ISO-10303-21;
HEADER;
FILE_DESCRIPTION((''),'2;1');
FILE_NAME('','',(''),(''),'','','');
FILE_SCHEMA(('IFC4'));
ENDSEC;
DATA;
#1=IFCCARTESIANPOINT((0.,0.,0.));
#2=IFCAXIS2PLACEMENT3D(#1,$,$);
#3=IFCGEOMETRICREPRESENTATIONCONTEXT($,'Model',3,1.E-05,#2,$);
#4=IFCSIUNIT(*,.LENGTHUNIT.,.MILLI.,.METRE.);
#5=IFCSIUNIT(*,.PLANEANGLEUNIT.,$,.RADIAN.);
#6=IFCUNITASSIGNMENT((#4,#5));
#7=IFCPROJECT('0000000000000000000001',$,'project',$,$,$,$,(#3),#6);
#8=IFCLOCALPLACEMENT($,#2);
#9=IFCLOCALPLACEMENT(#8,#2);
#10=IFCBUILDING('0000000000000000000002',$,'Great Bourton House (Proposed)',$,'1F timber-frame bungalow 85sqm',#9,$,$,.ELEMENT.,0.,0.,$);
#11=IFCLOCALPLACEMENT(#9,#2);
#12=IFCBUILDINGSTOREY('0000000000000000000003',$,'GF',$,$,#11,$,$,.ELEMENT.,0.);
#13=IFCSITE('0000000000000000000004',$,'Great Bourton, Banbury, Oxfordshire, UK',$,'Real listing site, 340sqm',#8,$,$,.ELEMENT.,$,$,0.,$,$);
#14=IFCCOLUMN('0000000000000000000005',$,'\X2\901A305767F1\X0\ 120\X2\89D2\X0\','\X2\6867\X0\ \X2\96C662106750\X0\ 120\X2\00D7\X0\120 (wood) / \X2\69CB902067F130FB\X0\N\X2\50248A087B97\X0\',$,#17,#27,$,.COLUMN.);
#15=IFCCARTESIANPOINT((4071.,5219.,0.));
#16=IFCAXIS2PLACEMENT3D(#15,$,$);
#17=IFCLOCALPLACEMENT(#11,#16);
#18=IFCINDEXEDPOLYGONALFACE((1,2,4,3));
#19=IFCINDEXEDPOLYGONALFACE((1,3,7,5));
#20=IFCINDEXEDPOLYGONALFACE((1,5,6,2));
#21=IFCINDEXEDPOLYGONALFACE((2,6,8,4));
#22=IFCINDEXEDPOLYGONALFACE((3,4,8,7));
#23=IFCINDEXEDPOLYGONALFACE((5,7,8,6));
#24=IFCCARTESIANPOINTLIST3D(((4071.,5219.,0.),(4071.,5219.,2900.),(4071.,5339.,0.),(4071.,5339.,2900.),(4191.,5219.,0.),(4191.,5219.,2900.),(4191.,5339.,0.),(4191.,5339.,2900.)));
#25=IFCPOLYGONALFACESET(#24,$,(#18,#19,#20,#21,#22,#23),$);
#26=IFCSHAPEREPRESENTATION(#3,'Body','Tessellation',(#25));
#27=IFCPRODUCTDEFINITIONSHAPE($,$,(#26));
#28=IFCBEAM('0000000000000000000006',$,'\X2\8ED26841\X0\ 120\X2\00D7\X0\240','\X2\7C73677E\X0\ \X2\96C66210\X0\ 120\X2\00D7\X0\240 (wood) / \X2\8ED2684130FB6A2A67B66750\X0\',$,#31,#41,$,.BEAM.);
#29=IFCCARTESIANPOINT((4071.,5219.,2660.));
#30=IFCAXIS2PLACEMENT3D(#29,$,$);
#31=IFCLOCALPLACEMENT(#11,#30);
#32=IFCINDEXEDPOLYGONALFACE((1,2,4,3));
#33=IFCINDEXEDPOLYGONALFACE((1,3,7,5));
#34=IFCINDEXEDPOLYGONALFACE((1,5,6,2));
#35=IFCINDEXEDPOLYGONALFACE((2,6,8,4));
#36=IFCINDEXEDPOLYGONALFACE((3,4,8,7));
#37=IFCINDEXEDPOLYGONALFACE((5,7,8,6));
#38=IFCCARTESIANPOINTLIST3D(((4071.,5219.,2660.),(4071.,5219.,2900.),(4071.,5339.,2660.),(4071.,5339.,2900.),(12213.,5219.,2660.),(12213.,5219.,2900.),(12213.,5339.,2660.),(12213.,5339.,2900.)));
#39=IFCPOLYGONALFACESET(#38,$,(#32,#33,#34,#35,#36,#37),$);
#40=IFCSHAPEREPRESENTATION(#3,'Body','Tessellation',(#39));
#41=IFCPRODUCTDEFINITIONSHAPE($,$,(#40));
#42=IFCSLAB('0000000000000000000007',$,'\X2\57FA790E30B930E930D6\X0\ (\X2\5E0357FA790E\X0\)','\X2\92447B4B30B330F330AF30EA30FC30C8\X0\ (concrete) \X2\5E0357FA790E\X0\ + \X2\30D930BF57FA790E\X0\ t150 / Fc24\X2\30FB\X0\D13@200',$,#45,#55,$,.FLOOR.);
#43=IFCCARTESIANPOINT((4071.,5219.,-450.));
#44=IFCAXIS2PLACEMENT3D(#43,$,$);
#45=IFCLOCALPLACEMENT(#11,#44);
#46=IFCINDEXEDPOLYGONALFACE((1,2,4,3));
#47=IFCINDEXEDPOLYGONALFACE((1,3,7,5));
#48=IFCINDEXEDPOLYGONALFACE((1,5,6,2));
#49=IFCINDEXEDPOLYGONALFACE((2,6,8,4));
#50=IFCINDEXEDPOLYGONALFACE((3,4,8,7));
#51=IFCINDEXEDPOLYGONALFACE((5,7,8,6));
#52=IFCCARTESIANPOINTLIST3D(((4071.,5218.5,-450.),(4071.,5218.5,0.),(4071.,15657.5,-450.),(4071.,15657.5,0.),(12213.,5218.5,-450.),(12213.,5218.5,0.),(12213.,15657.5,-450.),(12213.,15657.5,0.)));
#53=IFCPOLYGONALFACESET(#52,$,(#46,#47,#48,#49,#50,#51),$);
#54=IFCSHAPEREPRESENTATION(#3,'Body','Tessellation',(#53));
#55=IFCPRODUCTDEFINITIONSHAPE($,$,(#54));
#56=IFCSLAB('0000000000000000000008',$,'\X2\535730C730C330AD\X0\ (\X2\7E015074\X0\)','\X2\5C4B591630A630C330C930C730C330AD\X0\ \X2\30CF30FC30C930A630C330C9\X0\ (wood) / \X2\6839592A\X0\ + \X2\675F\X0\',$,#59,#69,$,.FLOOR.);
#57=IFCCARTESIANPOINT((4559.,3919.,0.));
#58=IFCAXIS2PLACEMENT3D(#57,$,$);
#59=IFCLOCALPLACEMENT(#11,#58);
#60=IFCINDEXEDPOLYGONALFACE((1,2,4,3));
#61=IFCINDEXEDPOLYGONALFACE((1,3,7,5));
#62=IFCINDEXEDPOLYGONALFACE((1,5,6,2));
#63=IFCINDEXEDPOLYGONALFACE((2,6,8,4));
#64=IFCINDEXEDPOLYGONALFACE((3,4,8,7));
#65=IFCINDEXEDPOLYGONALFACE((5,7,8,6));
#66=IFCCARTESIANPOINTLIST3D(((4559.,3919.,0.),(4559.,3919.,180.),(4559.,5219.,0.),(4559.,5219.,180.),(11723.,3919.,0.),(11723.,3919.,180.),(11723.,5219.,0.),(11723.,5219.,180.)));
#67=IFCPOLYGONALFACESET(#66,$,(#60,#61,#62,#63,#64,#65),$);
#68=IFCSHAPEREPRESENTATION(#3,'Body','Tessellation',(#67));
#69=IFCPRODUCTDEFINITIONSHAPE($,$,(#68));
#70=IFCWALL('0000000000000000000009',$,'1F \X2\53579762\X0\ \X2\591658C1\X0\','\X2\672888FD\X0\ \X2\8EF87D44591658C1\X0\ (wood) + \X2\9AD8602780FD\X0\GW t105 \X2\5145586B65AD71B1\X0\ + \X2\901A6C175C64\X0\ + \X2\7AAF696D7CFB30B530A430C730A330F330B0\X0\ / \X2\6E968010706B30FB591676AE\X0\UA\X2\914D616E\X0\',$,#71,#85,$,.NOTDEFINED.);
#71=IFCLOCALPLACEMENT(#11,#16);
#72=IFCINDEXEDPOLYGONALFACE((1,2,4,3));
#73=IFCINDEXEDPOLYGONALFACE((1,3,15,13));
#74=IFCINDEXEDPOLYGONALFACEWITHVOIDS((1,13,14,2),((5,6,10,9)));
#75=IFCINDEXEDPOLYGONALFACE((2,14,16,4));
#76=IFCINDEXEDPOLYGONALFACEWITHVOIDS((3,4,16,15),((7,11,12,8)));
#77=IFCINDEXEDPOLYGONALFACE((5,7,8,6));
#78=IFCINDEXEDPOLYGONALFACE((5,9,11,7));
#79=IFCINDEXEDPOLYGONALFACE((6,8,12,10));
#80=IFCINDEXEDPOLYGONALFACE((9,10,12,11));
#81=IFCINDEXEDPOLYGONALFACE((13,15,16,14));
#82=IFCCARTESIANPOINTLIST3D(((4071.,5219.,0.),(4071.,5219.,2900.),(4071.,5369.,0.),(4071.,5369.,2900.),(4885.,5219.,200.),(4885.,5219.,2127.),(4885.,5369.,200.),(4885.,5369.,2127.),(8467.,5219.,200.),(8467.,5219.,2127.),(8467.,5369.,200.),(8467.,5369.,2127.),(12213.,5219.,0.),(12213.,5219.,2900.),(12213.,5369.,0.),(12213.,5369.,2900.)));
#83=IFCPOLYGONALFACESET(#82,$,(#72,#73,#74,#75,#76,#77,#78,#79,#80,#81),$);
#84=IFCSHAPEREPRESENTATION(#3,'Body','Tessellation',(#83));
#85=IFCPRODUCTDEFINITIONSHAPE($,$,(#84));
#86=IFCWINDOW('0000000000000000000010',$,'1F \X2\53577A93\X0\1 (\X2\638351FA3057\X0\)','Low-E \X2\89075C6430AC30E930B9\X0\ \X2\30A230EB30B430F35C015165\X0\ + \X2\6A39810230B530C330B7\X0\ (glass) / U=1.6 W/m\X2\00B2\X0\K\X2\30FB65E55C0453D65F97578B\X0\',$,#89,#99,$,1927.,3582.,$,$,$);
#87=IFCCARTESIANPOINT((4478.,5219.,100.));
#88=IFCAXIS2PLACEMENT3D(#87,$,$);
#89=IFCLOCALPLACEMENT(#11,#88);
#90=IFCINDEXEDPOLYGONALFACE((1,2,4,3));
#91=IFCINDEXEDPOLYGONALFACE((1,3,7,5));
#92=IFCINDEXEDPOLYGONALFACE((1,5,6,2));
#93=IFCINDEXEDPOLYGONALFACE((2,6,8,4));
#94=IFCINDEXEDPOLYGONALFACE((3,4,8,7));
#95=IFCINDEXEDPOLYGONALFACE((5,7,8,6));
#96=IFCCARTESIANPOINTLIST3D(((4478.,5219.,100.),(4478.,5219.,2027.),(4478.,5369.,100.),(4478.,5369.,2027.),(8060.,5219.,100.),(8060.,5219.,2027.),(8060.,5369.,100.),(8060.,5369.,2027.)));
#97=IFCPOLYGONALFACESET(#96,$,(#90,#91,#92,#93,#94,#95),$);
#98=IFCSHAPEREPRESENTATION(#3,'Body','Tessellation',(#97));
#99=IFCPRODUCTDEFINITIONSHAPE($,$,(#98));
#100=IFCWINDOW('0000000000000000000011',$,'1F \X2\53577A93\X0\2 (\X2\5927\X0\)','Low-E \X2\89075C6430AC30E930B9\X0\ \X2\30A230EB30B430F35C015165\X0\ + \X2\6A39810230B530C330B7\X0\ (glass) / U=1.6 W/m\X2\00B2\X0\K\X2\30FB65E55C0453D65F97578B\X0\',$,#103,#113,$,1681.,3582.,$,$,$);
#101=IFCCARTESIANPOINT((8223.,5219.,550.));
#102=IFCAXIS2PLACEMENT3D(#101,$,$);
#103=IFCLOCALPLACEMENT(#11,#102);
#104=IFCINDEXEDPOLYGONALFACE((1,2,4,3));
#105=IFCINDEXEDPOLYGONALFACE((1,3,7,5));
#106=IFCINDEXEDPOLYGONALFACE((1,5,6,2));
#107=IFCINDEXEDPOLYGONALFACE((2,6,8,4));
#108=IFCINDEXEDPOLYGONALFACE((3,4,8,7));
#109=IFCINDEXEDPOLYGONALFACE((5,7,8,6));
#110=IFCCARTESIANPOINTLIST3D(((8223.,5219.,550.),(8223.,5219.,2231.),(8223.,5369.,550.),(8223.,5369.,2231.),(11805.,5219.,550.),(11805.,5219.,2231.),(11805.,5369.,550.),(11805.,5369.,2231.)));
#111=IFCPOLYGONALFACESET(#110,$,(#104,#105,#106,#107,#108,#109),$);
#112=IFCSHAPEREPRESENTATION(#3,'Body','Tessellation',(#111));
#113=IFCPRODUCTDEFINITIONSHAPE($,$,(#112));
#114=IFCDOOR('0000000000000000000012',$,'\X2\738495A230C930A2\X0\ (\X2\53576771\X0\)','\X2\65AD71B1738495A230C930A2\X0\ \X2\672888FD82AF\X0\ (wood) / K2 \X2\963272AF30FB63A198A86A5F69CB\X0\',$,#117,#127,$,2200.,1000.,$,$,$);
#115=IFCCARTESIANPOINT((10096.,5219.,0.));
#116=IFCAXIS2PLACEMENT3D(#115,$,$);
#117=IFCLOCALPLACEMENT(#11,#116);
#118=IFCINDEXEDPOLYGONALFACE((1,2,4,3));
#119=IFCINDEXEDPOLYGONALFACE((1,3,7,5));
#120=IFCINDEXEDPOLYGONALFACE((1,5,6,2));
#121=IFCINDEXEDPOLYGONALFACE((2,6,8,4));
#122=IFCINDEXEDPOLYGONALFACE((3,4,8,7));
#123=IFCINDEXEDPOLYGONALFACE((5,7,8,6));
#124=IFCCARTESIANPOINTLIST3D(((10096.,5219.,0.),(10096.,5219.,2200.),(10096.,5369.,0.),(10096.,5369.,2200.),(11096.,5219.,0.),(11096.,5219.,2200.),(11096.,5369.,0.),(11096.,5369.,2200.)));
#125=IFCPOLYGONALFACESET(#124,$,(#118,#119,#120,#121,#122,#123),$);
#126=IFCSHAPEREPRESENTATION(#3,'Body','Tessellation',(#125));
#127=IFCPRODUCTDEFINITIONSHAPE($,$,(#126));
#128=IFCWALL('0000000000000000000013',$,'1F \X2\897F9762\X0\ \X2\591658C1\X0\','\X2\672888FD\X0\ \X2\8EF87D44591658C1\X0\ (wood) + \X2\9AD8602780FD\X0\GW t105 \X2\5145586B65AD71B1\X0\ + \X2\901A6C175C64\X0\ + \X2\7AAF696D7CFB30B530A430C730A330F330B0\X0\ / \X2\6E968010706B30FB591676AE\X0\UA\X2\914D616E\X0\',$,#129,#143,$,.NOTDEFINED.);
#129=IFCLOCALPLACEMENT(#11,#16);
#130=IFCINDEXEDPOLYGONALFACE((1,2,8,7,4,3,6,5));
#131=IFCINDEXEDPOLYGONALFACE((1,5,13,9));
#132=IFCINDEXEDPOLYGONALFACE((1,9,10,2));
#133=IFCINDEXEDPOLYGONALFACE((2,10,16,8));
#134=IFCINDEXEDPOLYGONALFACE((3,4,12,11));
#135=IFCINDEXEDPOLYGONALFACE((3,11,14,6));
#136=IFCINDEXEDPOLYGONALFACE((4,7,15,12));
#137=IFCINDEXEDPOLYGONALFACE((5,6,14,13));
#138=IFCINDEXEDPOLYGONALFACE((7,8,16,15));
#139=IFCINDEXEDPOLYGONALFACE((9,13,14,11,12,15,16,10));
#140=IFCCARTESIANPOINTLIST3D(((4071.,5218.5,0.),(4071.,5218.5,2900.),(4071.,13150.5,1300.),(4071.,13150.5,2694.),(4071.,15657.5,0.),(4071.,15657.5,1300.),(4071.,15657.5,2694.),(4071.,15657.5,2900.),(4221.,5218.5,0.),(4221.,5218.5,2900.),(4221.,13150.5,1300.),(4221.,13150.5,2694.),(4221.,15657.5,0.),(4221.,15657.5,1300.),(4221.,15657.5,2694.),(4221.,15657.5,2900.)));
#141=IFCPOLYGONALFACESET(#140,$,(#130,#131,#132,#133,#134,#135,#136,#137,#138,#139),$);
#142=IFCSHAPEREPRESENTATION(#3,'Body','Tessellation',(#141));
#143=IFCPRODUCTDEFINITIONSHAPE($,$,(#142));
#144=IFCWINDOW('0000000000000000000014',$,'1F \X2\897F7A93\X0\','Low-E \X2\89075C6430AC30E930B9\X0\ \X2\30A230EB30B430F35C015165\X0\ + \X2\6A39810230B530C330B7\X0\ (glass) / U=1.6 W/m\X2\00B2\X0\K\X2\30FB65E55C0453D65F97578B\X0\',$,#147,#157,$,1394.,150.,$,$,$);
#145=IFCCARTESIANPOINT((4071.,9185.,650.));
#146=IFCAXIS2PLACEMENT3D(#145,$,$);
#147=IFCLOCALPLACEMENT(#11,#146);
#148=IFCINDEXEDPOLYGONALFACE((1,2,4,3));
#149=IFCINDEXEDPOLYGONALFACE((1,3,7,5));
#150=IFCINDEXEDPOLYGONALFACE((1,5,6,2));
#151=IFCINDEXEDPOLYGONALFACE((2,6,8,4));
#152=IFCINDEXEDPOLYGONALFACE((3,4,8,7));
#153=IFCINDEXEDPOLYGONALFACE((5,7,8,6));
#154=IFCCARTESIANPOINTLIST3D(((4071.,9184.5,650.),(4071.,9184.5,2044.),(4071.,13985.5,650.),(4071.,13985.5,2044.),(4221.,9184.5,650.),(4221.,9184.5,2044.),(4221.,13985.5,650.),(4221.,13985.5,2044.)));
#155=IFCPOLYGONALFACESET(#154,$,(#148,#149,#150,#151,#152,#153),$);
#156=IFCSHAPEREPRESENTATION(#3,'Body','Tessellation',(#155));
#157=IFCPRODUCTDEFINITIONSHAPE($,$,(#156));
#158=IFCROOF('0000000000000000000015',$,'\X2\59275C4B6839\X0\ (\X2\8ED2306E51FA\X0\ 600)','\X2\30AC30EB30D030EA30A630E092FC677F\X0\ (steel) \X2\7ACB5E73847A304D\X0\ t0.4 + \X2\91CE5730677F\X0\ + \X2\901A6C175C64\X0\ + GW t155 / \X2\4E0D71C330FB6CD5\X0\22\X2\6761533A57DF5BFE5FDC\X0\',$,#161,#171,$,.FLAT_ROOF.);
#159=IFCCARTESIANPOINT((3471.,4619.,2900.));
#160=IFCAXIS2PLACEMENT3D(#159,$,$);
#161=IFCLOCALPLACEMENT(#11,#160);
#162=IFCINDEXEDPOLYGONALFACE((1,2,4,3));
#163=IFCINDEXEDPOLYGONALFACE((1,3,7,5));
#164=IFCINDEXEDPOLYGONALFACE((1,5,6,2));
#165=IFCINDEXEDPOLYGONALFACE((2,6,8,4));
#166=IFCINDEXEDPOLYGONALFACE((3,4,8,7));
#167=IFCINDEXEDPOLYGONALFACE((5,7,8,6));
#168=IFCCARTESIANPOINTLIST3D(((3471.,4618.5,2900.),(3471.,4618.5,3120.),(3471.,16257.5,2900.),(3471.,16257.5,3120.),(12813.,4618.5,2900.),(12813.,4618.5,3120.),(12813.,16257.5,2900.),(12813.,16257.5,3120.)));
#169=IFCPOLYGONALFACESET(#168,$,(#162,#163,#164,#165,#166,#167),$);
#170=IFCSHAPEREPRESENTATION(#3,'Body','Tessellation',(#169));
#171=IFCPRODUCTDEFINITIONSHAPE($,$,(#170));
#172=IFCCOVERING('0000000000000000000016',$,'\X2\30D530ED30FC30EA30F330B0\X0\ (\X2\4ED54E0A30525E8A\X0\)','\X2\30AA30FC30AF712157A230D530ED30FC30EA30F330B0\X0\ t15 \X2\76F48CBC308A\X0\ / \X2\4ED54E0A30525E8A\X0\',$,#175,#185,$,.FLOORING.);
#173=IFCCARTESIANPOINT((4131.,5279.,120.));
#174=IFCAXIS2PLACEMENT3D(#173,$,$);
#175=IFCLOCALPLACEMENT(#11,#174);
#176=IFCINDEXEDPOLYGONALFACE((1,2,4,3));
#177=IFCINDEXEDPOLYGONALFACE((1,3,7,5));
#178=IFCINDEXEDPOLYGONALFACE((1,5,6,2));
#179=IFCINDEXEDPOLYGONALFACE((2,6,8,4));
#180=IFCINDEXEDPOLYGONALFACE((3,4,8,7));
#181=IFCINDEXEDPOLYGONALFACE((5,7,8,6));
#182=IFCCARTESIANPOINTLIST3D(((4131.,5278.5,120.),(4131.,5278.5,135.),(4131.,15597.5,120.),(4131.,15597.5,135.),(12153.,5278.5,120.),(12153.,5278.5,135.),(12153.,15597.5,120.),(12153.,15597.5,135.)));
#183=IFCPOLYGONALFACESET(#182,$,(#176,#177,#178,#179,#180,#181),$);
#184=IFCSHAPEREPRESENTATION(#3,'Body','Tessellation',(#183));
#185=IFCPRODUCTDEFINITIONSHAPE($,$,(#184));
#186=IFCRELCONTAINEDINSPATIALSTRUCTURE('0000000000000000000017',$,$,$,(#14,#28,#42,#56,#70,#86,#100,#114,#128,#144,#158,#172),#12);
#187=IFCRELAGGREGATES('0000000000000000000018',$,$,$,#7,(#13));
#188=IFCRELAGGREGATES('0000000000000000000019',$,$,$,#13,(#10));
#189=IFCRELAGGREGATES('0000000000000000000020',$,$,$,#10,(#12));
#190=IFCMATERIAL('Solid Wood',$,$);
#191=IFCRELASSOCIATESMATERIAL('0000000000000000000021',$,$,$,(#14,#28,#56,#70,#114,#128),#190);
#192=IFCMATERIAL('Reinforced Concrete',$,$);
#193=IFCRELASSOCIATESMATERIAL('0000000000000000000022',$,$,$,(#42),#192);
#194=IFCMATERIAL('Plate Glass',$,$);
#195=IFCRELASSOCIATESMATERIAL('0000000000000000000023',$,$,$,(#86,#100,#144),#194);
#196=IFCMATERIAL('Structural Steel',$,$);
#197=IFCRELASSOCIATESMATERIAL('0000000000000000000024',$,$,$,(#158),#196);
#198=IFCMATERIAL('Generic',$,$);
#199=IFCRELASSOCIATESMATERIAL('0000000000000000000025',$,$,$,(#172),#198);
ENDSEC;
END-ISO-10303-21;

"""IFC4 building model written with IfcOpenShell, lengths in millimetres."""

from ifc_helpers import new_model, si_unit, frame, frame_2d, origin, place, context, project, spatial, rectangle, extrude, material, element, fill, save


model = new_model("IFC4")

# Units and contexts
model_context = context("Model", 3, precision=1e-05, world=origin())
ifc_project = project(units=[si_unit("LENGTHUNIT", "METRE", prefix="MILLI"), si_unit("PLANEANGLEUNIT", "RADIAN")], contexts=[model_context])

# Site, building, storey
site_placement = place(None, origin())
site = spatial("IfcSite", under=ifc_project, at=site_placement, Name="Great Bourton, Banbury, Oxfordshire, UK", ObjectType="Real listing site, 340sqm", CompositionType="ELEMENT", RefElevation=0.0)
building_placement = place(site_placement, origin())
building = spatial("IfcBuilding", under=site, at=building_placement, Name="Great Bourton House (Proposed)", ObjectType="1F timber-frame bungalow 85sqm", CompositionType="ELEMENT", ElevationOfRefHeight=0.0, ElevationOfTerrain=0.0)
storey_placement = place(building_placement, origin())
storey = spatial("IfcBuildingStorey", under=building, at=storey_placement, Name="GF", CompositionType="ELEMENT", Elevation=0.0)

# Column
ifc_material_1 = material(Name="Solid Wood")
column_1_placement = place(storey_placement, frame((4071.0, 5219.0, 0.0)))
element("IfcColumn", 1, at=column_1_placement, inside=storey, material=ifc_material_1, Name="通し柱 120角", Description="桧 集成材 120×120 (wood) / 構造柱・N値計算", PredefinedType="COLUMN", context=model_context, shape_type="SweptSolid", body=[
    extrude(rectangle(XDim=120.0, YDim=120.0, at=frame_2d((60.0, 60.0))), frame((4071.0, 5219.0, 0.0)), (0.0, 0.0, 1.0), 2900.0),
])

# Beam
beam_1_placement = place(storey_placement, frame((4071.0, 5219.0, 2660.0)))
element("IfcBeam", 2, at=beam_1_placement, inside=storey, material=ifc_material_1, Name="軒桁 120×240", Description="米松 集成 120×240 (wood) / 軒桁・横架材", PredefinedType="BEAM", context=model_context, shape_type="SweptSolid", body=[
    extrude(rectangle(XDim=8142.0, YDim=120.0, at=frame_2d((4071.0, 60.0))), frame((4071.0, 5219.0, 2660.0)), (0.0, 0.0, 1.0), 240.0),
])

# Slabs
ifc_material_2 = material(Name="Reinforced Concrete")
slab_1_placement = place(storey_placement, frame((4071.0, 5219.0, -450.0)))
element("IfcSlab", 3, at=slab_1_placement, inside=storey, material=ifc_material_2, Name="基礎スラブ (布基礎)", Description="鉄筋コンクリート (concrete) 布基礎 + ベタ基礎 t150 / Fc24・D13@200", PredefinedType="FLOOR", context=model_context, shape_type="SweptSolid", body=[
    extrude(rectangle(XDim=8142.0, YDim=10439.0, at=frame_2d((4071.0, 5219.0))), frame((4071.0, 5219.0, -450.0)), (0.0, 0.0, 1.0), 450.0),
])
slab_2_placement = place(storey_placement, frame((4559.0, 3919.0, 0.0)))
element("IfcSlab", 4, at=slab_2_placement, inside=storey, material=ifc_material_1, Name="南デッキ (縁側)", Description="屋外ウッドデッキ ハードウッド (wood) / 根太 + 束", PredefinedType="FLOOR", context=model_context, shape_type="SweptSolid", body=[
    extrude(rectangle(XDim=7164.0, YDim=1300.0, at=frame_2d((3582.0, 650.0))), frame((4559.0, 3919.0, 0.0)), (0.0, 0.0, 1.0), 180.0),
])

# Wall, openings, windows, door
wall_1_placement = place(storey_placement, frame((4071.0, 5219.0, 0.0)))
wall_1 = element("IfcWall", 5, at=wall_1_placement, inside=storey, material=ifc_material_1, Name="1F 南面 外壁", Description="木製 軸組外壁 (wood) + 高性能GW t105 充填断熱 + 通気層 + 窯業系サイディング / 準耐火・外皮UA配慮", PredefinedType="NOTDEFINED", context=model_context, shape_type="SweptSolid", body=[
    extrude(rectangle(XDim=8142.0, YDim=150.0, at=frame_2d((4071.0, 75.0))), frame((4071.0, 5219.0, 0.0)), (0.0, 0.0, 1.0), 2900.0),
])
opening_1_placement = place(storey_placement, frame((4478.0, 5219.0, 100.0)))
opening_1 = element("IfcOpeningElement", 6, at=opening_1_placement, cuts=wall_1, PredefinedType="NOTDEFINED", context=model_context, shape_type="SweptSolid", body=[
    extrude(rectangle(XDim=3582.0, YDim=150.0, at=frame_2d((1791.0, 75.0))), frame((4478.0, 5219.0, 100.0)), (0.0, 0.0, 1.0), 1927.0),
])
opening_2_placement = place(storey_placement, frame((8223.0, 5219.0, 550.0)))
opening_2 = element("IfcOpeningElement", 7, at=opening_2_placement, cuts=wall_1, PredefinedType="NOTDEFINED", context=model_context, shape_type="SweptSolid", body=[
    extrude(rectangle(XDim=3582.0, YDim=150.0, at=frame_2d((1791.0, 75.0))), frame((8223.0, 5219.0, 550.0)), (0.0, 0.0, 1.0), 1681.0),
])
opening_3_placement = place(storey_placement, frame((10096.0, 5219.0, 0.0)))
opening_3 = element("IfcOpeningElement", 8, at=opening_3_placement, cuts=wall_1, PredefinedType="NOTDEFINED", context=model_context, shape_type="SweptSolid", body=[
    extrude(rectangle(XDim=1000.0, YDim=150.0, at=frame_2d((500.0, 75.0))), frame((10096.0, 5219.0, 0.0)), (0.0, 0.0, 1.0), 2200.0),
])
ifc_material_3 = material(Name="Plate Glass")
window_1_placement = place(storey_placement, frame((4478.0, 5219.0, 100.0)))
window_1 = element("IfcWindow", 9, at=window_1_placement, inside=storey, material=ifc_material_3, Name="1F 南窓1 (掃出し)", Description="Low-E 複層ガラス アルゴン封入 + 樹脂サッシ (glass) / U=1.6 W/m²K・日射取得型", OverallHeight=1927.0, OverallWidth=3582.0, context=model_context, shape_type="SweptSolid", body=[
    extrude(rectangle(XDim=3582.0, YDim=150.0, at=frame_2d((1791.0, 75.0))), frame((4478.0, 5219.0, 100.0)), (0.0, 0.0, 1.0), 1927.0),
])
fill(opening_1, window_1)
window_2_placement = place(storey_placement, frame((8223.0, 5219.0, 550.0)))
window_2 = element("IfcWindow", 10, at=window_2_placement, inside=storey, material=ifc_material_3, Name="1F 南窓2 (大)", Description="Low-E 複層ガラス アルゴン封入 + 樹脂サッシ (glass) / U=1.6 W/m²K・日射取得型", OverallHeight=1681.0, OverallWidth=3582.0, context=model_context, shape_type="SweptSolid", body=[
    extrude(rectangle(XDim=3582.0, YDim=150.0, at=frame_2d((1791.0, 75.0))), frame((8223.0, 5219.0, 550.0)), (0.0, 0.0, 1.0), 1681.0),
])
fill(opening_2, window_2)
door_placement = place(storey_placement, frame((10096.0, 5219.0, 0.0)))
door = element("IfcDoor", 11, at=door_placement, inside=storey, material=ifc_material_1, Name="玄関ドア (南東)", Description="断熱玄関ドア 木製芯 (wood) / K2 防犯・採風機構", OverallHeight=2200.0, OverallWidth=1000.0, context=model_context, shape_type="SweptSolid", body=[
    extrude(rectangle(XDim=1000.0, YDim=150.0, at=frame_2d((500.0, 75.0))), frame((10096.0, 5219.0, 0.0)), (0.0, 0.0, 1.0), 2200.0),
])
fill(opening_3, door)

# Wall, opening, window
wall_2_placement = place(storey_placement, frame((4071.0, 5219.0, 0.0)))
wall_2 = element("IfcWall", 12, at=wall_2_placement, inside=storey, material=ifc_material_1, Name="1F 西面 外壁", Description="木製 軸組外壁 (wood) + 高性能GW t105 充填断熱 + 通気層 + 窯業系サイディング / 準耐火・外皮UA配慮", PredefinedType="NOTDEFINED", context=model_context, shape_type="SweptSolid", body=[
    extrude(rectangle(XDim=150.0, YDim=10439.0, at=frame_2d((75.0, 5219.0))), frame((4071.0, 5219.0, 0.0)), (0.0, 0.0, 1.0), 2900.0),
])
opening_4_placement = place(storey_placement, frame((4071.0, 9185.0, 650.0)))
opening_4 = element("IfcOpeningElement", 13, at=opening_4_placement, cuts=wall_2, PredefinedType="NOTDEFINED", context=model_context, shape_type="SweptSolid", body=[
    extrude(rectangle(XDim=150.0, YDim=4801.0, at=frame_2d((75.0, 2400.0))), frame((4071.0, 9185.0, 650.0)), (0.0, 0.0, 1.0), 1394.0),
])
window_3_placement = place(storey_placement, frame((4071.0, 9185.0, 650.0)))
window_3 = element("IfcWindow", 14, at=window_3_placement, inside=storey, material=ifc_material_3, Name="1F 西窓", Description="Low-E 複層ガラス アルゴン封入 + 樹脂サッシ (glass) / U=1.6 W/m²K・日射取得型", OverallHeight=1394.0, OverallWidth=150.0, context=model_context, shape_type="SweptSolid", body=[
    extrude(rectangle(XDim=150.0, YDim=4801.0, at=frame_2d((75.0, 2400.0))), frame((4071.0, 9185.0, 650.0)), (0.0, 0.0, 1.0), 1394.0),
])
fill(opening_4, window_3)

# Roof
ifc_material_4 = material(Name="Structural Steel")
roof_placement = place(storey_placement, frame((3471.0, 4619.0, 2900.0)))
element("IfcRoof", 15, at=roof_placement, inside=storey, material=ifc_material_4, Name="大屋根 (軒の出 600)", Description="ガルバリウム鋼板 (steel) 立平葺き t0.4 + 野地板 + 通気層 + GW t155 / 不燃・法22条区域対応", PredefinedType="FLAT_ROOF", context=model_context, shape_type="SweptSolid", body=[
    extrude(rectangle(XDim=9342.0, YDim=11639.0, at=frame_2d((4671.0, 5819.0))), frame((3471.0, 4619.0, 2900.0)), (0.0, 0.0, 1.0), 220.0),
])

# Covering
ifc_material_5 = material(Name="Generic")
covering_1_placement = place(storey_placement, frame((4131.0, 5279.0, 120.0)))
element("IfcCovering", 16, at=covering_1_placement, inside=storey, material=ifc_material_5, Name="フローリング (仕上げ床)", Description="オーク無垢フローリング t15 直貼り / 仕上げ床", PredefinedType="FLOORING", context=model_context, shape_type="SweptSolid", body=[
    extrude(rectangle(XDim=8022.0, YDim=10319.0, at=frame_2d((4011.0, 5159.0))), frame((4131.0, 5279.0, 120.0)), (0.0, 0.0, 1.0), 15.0),
])

save(model, "model.ifc")
